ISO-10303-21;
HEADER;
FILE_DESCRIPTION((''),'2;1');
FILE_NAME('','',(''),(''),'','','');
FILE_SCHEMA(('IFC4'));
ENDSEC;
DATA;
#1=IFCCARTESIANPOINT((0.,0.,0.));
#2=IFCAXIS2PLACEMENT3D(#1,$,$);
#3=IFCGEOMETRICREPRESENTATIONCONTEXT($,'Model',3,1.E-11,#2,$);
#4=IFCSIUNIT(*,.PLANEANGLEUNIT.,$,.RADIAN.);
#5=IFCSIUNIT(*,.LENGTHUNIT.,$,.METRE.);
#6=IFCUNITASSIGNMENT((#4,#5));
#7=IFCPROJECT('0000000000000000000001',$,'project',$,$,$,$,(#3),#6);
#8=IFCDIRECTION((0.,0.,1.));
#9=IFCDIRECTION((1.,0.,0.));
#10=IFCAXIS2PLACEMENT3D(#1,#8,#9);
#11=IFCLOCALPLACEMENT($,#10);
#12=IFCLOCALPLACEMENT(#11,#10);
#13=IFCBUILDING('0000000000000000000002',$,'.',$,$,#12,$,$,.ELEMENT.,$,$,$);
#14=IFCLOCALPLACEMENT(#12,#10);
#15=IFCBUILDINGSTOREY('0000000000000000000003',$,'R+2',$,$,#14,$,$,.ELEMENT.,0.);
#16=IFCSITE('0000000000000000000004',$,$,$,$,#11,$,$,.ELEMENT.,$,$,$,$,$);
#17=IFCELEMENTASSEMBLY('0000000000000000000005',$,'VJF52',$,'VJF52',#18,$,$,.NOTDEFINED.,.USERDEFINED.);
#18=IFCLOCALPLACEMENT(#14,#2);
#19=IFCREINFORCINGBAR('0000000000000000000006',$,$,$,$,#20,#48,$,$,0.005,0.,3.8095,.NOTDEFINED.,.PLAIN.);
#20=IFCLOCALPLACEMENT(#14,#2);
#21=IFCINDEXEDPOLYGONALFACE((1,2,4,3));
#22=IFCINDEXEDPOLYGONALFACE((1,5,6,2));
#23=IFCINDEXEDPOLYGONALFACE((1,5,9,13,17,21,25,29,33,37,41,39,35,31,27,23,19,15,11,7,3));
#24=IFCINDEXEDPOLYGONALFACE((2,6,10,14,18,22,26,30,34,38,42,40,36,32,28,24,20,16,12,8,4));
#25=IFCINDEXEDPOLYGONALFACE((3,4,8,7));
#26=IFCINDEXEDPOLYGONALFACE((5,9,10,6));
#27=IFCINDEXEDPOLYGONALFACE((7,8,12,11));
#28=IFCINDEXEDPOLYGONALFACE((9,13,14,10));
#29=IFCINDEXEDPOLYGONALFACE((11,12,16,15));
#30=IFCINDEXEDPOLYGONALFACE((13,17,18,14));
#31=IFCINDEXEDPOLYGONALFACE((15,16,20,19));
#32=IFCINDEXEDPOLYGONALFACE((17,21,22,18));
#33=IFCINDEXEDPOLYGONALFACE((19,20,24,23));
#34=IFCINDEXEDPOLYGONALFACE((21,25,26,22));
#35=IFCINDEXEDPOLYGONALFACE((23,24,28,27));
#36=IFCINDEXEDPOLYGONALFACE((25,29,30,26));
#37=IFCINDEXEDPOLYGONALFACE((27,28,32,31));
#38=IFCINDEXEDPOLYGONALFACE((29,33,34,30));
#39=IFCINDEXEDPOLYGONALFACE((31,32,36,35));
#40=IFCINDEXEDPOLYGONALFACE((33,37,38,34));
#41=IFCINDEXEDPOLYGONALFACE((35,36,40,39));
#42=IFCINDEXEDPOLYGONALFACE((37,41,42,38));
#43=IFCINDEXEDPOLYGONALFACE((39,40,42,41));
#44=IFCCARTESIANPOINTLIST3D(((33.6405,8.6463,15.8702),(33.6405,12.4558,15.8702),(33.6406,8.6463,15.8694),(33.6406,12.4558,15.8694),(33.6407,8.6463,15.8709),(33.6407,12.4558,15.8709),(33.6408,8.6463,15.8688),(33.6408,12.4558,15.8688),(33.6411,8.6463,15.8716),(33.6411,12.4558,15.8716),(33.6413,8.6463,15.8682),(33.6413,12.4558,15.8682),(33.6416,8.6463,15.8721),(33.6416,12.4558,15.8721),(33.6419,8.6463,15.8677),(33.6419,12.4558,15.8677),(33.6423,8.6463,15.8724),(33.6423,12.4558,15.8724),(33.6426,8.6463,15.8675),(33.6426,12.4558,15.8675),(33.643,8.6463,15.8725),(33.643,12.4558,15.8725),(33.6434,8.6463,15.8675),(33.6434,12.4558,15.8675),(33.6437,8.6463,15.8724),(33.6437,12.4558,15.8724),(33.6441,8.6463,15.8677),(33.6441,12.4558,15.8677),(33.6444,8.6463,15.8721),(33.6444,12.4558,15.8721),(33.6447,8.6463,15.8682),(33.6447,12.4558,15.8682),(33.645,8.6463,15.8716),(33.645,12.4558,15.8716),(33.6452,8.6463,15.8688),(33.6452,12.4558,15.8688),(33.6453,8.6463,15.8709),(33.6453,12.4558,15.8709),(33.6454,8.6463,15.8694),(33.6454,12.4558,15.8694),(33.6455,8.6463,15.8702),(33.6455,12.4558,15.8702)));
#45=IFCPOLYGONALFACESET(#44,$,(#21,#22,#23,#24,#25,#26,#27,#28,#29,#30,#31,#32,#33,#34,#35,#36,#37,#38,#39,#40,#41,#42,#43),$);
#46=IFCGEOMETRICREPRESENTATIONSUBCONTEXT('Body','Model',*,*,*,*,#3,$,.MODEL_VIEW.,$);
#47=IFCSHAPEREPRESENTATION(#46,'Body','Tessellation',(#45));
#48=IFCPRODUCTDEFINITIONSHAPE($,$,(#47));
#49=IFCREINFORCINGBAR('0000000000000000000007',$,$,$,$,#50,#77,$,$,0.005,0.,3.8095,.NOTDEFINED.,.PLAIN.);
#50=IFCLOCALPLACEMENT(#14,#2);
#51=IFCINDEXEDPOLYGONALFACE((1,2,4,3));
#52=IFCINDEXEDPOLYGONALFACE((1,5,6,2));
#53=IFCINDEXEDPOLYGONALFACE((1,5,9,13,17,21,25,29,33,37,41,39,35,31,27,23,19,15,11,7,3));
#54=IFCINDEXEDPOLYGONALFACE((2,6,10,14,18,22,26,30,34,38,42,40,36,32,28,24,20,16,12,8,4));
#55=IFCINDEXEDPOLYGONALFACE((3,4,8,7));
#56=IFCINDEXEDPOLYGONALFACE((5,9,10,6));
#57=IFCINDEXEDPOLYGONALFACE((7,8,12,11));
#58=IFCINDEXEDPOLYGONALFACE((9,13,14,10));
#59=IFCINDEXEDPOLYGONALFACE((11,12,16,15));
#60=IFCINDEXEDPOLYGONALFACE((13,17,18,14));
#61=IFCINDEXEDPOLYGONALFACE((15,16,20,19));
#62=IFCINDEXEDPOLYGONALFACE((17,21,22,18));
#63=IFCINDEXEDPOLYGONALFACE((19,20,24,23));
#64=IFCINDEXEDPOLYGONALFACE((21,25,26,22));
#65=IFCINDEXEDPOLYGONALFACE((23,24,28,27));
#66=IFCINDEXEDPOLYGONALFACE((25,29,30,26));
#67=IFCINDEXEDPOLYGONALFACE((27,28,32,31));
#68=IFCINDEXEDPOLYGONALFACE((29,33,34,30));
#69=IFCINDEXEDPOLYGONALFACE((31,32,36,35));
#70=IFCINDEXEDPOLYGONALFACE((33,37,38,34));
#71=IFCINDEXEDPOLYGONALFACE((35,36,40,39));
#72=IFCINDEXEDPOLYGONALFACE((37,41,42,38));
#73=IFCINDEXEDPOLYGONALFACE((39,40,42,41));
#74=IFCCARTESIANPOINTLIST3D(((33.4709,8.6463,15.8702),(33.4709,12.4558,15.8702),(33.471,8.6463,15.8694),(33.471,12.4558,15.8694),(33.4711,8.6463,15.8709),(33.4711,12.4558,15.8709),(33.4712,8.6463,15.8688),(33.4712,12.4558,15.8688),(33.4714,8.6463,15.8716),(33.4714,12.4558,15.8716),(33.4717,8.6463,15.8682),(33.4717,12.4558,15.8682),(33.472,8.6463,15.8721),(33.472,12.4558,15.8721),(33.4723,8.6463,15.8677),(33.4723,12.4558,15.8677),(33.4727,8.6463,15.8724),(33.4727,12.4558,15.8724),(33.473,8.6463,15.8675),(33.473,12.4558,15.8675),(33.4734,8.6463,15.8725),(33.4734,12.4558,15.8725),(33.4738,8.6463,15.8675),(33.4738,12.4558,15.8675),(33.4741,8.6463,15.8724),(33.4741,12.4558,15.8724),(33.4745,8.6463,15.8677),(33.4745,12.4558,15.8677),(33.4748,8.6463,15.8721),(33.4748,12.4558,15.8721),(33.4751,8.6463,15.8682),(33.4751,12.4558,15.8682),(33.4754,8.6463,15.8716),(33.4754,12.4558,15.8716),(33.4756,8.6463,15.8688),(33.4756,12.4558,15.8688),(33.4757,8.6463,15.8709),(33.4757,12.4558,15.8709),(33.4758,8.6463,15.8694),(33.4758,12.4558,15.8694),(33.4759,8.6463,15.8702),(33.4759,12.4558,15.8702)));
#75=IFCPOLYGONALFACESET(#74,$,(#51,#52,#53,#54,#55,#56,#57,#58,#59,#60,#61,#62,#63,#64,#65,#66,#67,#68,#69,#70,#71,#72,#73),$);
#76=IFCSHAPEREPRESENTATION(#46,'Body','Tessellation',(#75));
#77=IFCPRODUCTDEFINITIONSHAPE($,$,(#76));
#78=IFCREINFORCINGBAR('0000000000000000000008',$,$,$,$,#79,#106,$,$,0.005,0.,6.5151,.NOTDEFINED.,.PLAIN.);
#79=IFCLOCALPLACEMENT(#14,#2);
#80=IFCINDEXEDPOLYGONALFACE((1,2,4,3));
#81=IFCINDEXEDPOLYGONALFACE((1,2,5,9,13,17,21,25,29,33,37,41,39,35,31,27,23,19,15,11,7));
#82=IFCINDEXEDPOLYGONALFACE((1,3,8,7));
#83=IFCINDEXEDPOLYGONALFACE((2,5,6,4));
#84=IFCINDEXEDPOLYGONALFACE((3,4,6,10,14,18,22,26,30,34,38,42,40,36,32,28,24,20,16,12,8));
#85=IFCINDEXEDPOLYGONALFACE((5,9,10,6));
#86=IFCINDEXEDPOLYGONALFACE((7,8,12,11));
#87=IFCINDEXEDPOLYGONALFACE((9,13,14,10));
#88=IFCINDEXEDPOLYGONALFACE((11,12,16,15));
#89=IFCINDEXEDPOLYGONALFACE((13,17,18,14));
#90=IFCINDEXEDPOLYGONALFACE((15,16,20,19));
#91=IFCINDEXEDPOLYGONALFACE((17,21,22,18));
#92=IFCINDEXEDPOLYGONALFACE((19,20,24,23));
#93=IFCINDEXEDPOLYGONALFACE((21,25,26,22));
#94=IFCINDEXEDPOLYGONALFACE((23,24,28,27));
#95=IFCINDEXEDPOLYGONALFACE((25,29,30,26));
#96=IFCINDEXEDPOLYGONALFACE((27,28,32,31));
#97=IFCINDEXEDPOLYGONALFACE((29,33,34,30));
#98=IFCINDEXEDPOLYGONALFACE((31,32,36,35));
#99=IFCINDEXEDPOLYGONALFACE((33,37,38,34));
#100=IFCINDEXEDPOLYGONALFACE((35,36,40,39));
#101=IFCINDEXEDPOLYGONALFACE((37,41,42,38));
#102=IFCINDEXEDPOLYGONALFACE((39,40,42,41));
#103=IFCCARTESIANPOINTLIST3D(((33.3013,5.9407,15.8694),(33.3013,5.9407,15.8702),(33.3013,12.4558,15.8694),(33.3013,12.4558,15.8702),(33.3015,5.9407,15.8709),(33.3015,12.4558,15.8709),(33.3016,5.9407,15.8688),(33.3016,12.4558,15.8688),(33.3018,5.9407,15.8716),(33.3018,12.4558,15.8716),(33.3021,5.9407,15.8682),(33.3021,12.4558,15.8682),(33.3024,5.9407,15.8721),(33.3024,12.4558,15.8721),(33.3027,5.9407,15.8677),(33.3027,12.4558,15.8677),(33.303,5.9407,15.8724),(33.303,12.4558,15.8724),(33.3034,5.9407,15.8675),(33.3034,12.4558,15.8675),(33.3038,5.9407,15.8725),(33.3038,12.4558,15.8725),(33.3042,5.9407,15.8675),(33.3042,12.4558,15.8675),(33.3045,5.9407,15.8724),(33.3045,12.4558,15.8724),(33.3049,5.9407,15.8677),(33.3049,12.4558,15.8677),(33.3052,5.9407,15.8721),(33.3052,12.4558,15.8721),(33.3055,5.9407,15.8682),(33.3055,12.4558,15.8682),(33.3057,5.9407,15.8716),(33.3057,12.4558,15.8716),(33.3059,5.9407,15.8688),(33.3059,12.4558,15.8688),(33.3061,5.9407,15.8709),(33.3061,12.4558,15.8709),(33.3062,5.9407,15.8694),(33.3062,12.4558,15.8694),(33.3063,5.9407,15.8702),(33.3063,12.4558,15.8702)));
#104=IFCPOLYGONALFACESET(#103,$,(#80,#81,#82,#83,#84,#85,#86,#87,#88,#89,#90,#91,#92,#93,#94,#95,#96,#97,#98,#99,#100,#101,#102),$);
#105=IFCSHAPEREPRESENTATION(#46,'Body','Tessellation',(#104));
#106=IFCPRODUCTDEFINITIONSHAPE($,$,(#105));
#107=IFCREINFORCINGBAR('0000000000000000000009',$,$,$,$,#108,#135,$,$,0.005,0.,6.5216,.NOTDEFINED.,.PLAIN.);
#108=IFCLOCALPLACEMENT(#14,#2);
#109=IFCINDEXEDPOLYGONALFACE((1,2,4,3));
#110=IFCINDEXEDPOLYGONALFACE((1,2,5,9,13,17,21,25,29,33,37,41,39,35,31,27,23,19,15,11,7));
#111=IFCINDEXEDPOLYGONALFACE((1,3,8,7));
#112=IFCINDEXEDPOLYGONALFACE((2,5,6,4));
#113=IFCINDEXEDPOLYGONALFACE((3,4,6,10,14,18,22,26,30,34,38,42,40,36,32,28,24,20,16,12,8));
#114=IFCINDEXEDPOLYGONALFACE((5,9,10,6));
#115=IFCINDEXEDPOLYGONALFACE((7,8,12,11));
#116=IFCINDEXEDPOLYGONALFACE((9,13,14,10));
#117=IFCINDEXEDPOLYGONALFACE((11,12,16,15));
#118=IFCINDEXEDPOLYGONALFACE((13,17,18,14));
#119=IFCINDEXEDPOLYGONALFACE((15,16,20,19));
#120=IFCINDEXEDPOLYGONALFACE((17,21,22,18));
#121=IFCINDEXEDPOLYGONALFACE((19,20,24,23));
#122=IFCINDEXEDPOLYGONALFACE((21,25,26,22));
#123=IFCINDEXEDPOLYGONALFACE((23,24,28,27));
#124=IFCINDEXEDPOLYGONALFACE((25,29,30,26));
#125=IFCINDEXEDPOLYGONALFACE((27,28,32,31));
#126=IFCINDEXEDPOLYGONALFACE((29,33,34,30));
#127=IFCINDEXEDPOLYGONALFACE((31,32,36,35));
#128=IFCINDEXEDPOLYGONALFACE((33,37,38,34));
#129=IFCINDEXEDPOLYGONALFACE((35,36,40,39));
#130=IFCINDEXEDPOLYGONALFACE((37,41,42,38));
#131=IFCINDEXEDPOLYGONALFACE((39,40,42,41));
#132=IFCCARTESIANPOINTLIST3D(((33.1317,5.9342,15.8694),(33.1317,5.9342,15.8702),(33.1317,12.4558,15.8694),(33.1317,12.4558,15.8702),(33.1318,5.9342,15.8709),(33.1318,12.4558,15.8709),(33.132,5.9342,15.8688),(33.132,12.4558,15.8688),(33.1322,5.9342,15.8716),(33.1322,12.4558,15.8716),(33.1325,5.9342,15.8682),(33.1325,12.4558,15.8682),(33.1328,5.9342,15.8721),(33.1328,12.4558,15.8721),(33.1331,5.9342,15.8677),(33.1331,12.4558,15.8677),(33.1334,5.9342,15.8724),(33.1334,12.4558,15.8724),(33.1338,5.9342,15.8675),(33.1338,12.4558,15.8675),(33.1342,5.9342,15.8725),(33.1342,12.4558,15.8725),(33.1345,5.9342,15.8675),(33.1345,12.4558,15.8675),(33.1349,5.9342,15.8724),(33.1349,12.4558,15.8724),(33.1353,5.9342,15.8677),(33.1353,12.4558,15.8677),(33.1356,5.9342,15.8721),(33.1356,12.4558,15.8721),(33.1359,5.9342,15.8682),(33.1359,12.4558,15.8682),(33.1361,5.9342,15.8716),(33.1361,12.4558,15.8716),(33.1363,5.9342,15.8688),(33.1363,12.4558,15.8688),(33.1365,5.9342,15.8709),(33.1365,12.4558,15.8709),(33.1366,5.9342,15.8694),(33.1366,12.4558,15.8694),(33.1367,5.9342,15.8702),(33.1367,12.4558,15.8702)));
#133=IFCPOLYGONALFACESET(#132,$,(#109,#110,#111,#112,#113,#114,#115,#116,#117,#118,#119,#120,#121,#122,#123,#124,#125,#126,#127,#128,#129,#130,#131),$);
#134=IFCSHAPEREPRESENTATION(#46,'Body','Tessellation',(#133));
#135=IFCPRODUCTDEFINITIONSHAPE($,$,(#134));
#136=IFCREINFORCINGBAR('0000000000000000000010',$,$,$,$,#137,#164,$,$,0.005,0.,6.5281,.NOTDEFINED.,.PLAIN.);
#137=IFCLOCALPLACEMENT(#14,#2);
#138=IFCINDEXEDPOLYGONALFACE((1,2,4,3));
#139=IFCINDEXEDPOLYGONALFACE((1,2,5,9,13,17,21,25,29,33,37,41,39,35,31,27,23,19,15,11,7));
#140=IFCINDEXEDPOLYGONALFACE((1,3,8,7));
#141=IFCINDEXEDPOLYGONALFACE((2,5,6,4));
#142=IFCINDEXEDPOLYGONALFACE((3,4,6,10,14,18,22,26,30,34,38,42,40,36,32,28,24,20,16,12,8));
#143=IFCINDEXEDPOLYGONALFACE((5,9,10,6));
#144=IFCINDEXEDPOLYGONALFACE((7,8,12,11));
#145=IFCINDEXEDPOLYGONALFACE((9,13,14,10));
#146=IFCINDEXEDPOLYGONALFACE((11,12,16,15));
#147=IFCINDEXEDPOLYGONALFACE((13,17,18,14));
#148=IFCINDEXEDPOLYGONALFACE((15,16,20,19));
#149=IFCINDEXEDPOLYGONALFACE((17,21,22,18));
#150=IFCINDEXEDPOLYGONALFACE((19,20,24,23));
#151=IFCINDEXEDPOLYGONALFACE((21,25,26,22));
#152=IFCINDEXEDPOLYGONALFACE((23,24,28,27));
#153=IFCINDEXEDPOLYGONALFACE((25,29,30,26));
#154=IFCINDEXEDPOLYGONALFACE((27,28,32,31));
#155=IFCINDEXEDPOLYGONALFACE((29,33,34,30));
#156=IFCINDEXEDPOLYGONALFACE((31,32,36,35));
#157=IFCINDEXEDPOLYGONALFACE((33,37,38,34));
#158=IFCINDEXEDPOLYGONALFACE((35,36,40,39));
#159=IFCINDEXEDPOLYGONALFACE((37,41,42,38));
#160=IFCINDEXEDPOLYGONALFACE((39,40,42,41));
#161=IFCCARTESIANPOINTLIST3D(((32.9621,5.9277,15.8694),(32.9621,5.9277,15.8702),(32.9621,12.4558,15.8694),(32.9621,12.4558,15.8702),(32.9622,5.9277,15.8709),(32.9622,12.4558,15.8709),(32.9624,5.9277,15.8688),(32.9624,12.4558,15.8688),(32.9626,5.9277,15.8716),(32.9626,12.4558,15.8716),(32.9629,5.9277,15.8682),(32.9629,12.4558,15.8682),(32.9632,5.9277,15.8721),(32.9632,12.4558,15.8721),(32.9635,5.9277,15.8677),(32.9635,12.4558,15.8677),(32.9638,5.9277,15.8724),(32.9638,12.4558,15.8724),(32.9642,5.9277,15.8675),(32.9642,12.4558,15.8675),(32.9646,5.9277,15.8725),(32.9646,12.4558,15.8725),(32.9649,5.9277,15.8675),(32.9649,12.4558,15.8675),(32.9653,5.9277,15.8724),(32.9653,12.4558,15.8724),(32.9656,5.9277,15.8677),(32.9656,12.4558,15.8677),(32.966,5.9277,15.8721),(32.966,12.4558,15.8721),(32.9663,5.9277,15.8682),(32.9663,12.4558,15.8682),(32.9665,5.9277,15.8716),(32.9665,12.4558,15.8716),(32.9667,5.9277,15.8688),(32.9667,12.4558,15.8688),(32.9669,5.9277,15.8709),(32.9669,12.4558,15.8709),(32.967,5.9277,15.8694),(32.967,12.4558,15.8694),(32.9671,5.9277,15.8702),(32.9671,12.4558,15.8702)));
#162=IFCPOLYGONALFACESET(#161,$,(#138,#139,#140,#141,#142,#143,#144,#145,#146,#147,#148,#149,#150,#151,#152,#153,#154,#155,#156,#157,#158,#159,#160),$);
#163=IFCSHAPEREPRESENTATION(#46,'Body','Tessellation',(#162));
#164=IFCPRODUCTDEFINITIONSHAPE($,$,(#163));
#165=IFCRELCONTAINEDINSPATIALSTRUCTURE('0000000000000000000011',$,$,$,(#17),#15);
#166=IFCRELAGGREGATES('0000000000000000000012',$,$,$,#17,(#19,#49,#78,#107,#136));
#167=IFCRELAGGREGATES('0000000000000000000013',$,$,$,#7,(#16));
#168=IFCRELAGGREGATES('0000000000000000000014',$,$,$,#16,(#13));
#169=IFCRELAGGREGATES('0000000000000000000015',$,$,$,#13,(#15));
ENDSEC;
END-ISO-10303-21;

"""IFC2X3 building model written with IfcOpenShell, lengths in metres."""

from ifc_helpers import new_model, entity, si_unit, origin, origin_with_axes, place, context, subcontext, project, spatial, shape, element, aggregate, save


model = new_model("IFC2X3")

# Units and contexts
model_context = context("Model", 3, precision=1e-11, world=origin())
body_context = subcontext(model_context, "Body", "Model", "MODEL_VIEW")
ifc_project = project(units=[si_unit("PLANEANGLEUNIT", "RADIAN"), si_unit("LENGTHUNIT", "METRE")], contexts=[model_context])

# Site, building, storey
site_placement = place(None, origin_with_axes())
site = spatial("IfcSite", under=ifc_project, at=site_placement, CompositionType="ELEMENT")
building_placement = place(site_placement, origin_with_axes())
building = spatial("IfcBuilding", under=site, at=building_placement, Name=".", CompositionType="ELEMENT")
storey_placement = place(building_placement, origin_with_axes())
storey = spatial("IfcBuildingStorey", under=building, at=storey_placement, Name="R+2", CompositionType="ELEMENT", Elevation=0.0)

# Element assembly, reinforcing bars
assembly_1_placement = place(storey_placement, origin_with_axes())
assembly_1 = element("IfcElementAssembly", 1, at=assembly_1_placement, inside=storey, Name="VJF52", ObjectType="VJF52", AssemblyPlace="NOTDEFINED", PredefinedType="USERDEFINED")
reinforcing_bar_1_placement = place(assembly_1_placement, origin_with_axes())
reinforcing_bar_1 = element("IfcReinforcingBar", 2, at=reinforcing_bar_1_placement, BarLength=3.8095, BarRole="NOTDEFINED", BarSurface="PLAIN", CrossSectionArea=0.0, NominalDiameter=0.005, shapes=[
    shape(body_context, "Body", "AdvancedSweptSolid", [entity("IfcSweptDiskSolid", entity("IfcPolyline", [entity("IfcCartesianPoint", [33.643, 8.6463, 15.87]), entity("IfcCartesianPoint", [33.643, 12.4558, 15.87])]), 0.0025, None, 0.0, 3.8095)]),
    shape(body_context, "Body", "AdvancedSweptSolid", [entity("IfcSweptDiskSolid", entity("IfcPolyline", [entity("IfcCartesianPoint", [33.643, 8.6463, 15.87]), entity("IfcCartesianPoint", [33.643, 12.4558, 15.87])]), 0.0025, None, 0.0, 3.8095)]),
])
reinforcing_bar_2_placement = place(assembly_1_placement, origin_with_axes())
reinforcing_bar_2 = element("IfcReinforcingBar", 3, at=reinforcing_bar_2_placement, BarLength=3.8095, BarRole="NOTDEFINED", BarSurface="PLAIN", CrossSectionArea=0.0, NominalDiameter=0.005, shapes=[
    shape(body_context, "Body", "AdvancedSweptSolid", [entity("IfcSweptDiskSolid", entity("IfcPolyline", [entity("IfcCartesianPoint", [33.4734, 8.6463, 15.87]), entity("IfcCartesianPoint", [33.4734, 12.4558, 15.87])]), 0.0025, None, 0.0, 3.8095)]),
    shape(body_context, "Body", "AdvancedSweptSolid", [entity("IfcSweptDiskSolid", entity("IfcPolyline", [entity("IfcCartesianPoint", [33.4734, 8.6463, 15.87]), entity("IfcCartesianPoint", [33.4734, 12.4558, 15.87])]), 0.0025, None, 0.0, 3.8095)]),
])
reinforcing_bar_3_placement = place(assembly_1_placement, origin_with_axes())
reinforcing_bar_3 = element("IfcReinforcingBar", 4, at=reinforcing_bar_3_placement, BarLength=6.5151, BarRole="NOTDEFINED", BarSurface="PLAIN", CrossSectionArea=0.0, NominalDiameter=0.005, shapes=[
    shape(body_context, "Body", "AdvancedSweptSolid", [entity("IfcSweptDiskSolid", entity("IfcPolyline", [entity("IfcCartesianPoint", [33.3038, 5.9407, 15.87]), entity("IfcCartesianPoint", [33.3038, 12.4558, 15.87])]), 0.0025, None, 0.0, 6.5151)]),
    shape(body_context, "Body", "AdvancedSweptSolid", [entity("IfcSweptDiskSolid", entity("IfcPolyline", [entity("IfcCartesianPoint", [33.3038, 5.9407, 15.87]), entity("IfcCartesianPoint", [33.3038, 12.4558, 15.87])]), 0.0025, None, 0.0, 6.5151)]),
])
reinforcing_bar_4_placement = place(assembly_1_placement, origin_with_axes())
reinforcing_bar_4 = element("IfcReinforcingBar", 5, at=reinforcing_bar_4_placement, BarLength=6.5216, BarRole="NOTDEFINED", BarSurface="PLAIN", CrossSectionArea=0.0, NominalDiameter=0.005, shapes=[
    shape(body_context, "Body", "AdvancedSweptSolid", [entity("IfcSweptDiskSolid", entity("IfcPolyline", [entity("IfcCartesianPoint", [33.1342, 5.9342, 15.87]), entity("IfcCartesianPoint", [33.1342, 12.4558, 15.87])]), 0.0025, None, 0.0, 6.5216)]),
    shape(body_context, "Body", "AdvancedSweptSolid", [entity("IfcSweptDiskSolid", entity("IfcPolyline", [entity("IfcCartesianPoint", [33.1342, 5.9342, 15.87]), entity("IfcCartesianPoint", [33.1342, 12.4558, 15.87])]), 0.0025, None, 0.0, 6.5216)]),
])
reinforcing_bar_5_placement = place(assembly_1_placement, origin_with_axes())
reinforcing_bar_5 = element("IfcReinforcingBar", 6, at=reinforcing_bar_5_placement, BarLength=6.5281, BarRole="NOTDEFINED", BarSurface="PLAIN", CrossSectionArea=0.0, NominalDiameter=0.005, shapes=[
    shape(body_context, "Body", "AdvancedSweptSolid", [entity("IfcSweptDiskSolid", entity("IfcPolyline", [entity("IfcCartesianPoint", [32.9646, 5.9277, 15.87]), entity("IfcCartesianPoint", [32.9646, 12.4558, 15.87])]), 0.0025, None, 0.0, 6.5281)]),
    shape(body_context, "Body", "AdvancedSweptSolid", [entity("IfcSweptDiskSolid", entity("IfcPolyline", [entity("IfcCartesianPoint", [32.9646, 5.9277, 15.87]), entity("IfcCartesianPoint", [32.9646, 12.4558, 15.87])]), 0.0025, None, 0.0, 6.5281)]),
])
aggregate(assembly_1, [reinforcing_bar_1, reinforcing_bar_2, reinforcing_bar_3, reinforcing_bar_4, reinforcing_bar_5])

save(model, "model.ifc")
